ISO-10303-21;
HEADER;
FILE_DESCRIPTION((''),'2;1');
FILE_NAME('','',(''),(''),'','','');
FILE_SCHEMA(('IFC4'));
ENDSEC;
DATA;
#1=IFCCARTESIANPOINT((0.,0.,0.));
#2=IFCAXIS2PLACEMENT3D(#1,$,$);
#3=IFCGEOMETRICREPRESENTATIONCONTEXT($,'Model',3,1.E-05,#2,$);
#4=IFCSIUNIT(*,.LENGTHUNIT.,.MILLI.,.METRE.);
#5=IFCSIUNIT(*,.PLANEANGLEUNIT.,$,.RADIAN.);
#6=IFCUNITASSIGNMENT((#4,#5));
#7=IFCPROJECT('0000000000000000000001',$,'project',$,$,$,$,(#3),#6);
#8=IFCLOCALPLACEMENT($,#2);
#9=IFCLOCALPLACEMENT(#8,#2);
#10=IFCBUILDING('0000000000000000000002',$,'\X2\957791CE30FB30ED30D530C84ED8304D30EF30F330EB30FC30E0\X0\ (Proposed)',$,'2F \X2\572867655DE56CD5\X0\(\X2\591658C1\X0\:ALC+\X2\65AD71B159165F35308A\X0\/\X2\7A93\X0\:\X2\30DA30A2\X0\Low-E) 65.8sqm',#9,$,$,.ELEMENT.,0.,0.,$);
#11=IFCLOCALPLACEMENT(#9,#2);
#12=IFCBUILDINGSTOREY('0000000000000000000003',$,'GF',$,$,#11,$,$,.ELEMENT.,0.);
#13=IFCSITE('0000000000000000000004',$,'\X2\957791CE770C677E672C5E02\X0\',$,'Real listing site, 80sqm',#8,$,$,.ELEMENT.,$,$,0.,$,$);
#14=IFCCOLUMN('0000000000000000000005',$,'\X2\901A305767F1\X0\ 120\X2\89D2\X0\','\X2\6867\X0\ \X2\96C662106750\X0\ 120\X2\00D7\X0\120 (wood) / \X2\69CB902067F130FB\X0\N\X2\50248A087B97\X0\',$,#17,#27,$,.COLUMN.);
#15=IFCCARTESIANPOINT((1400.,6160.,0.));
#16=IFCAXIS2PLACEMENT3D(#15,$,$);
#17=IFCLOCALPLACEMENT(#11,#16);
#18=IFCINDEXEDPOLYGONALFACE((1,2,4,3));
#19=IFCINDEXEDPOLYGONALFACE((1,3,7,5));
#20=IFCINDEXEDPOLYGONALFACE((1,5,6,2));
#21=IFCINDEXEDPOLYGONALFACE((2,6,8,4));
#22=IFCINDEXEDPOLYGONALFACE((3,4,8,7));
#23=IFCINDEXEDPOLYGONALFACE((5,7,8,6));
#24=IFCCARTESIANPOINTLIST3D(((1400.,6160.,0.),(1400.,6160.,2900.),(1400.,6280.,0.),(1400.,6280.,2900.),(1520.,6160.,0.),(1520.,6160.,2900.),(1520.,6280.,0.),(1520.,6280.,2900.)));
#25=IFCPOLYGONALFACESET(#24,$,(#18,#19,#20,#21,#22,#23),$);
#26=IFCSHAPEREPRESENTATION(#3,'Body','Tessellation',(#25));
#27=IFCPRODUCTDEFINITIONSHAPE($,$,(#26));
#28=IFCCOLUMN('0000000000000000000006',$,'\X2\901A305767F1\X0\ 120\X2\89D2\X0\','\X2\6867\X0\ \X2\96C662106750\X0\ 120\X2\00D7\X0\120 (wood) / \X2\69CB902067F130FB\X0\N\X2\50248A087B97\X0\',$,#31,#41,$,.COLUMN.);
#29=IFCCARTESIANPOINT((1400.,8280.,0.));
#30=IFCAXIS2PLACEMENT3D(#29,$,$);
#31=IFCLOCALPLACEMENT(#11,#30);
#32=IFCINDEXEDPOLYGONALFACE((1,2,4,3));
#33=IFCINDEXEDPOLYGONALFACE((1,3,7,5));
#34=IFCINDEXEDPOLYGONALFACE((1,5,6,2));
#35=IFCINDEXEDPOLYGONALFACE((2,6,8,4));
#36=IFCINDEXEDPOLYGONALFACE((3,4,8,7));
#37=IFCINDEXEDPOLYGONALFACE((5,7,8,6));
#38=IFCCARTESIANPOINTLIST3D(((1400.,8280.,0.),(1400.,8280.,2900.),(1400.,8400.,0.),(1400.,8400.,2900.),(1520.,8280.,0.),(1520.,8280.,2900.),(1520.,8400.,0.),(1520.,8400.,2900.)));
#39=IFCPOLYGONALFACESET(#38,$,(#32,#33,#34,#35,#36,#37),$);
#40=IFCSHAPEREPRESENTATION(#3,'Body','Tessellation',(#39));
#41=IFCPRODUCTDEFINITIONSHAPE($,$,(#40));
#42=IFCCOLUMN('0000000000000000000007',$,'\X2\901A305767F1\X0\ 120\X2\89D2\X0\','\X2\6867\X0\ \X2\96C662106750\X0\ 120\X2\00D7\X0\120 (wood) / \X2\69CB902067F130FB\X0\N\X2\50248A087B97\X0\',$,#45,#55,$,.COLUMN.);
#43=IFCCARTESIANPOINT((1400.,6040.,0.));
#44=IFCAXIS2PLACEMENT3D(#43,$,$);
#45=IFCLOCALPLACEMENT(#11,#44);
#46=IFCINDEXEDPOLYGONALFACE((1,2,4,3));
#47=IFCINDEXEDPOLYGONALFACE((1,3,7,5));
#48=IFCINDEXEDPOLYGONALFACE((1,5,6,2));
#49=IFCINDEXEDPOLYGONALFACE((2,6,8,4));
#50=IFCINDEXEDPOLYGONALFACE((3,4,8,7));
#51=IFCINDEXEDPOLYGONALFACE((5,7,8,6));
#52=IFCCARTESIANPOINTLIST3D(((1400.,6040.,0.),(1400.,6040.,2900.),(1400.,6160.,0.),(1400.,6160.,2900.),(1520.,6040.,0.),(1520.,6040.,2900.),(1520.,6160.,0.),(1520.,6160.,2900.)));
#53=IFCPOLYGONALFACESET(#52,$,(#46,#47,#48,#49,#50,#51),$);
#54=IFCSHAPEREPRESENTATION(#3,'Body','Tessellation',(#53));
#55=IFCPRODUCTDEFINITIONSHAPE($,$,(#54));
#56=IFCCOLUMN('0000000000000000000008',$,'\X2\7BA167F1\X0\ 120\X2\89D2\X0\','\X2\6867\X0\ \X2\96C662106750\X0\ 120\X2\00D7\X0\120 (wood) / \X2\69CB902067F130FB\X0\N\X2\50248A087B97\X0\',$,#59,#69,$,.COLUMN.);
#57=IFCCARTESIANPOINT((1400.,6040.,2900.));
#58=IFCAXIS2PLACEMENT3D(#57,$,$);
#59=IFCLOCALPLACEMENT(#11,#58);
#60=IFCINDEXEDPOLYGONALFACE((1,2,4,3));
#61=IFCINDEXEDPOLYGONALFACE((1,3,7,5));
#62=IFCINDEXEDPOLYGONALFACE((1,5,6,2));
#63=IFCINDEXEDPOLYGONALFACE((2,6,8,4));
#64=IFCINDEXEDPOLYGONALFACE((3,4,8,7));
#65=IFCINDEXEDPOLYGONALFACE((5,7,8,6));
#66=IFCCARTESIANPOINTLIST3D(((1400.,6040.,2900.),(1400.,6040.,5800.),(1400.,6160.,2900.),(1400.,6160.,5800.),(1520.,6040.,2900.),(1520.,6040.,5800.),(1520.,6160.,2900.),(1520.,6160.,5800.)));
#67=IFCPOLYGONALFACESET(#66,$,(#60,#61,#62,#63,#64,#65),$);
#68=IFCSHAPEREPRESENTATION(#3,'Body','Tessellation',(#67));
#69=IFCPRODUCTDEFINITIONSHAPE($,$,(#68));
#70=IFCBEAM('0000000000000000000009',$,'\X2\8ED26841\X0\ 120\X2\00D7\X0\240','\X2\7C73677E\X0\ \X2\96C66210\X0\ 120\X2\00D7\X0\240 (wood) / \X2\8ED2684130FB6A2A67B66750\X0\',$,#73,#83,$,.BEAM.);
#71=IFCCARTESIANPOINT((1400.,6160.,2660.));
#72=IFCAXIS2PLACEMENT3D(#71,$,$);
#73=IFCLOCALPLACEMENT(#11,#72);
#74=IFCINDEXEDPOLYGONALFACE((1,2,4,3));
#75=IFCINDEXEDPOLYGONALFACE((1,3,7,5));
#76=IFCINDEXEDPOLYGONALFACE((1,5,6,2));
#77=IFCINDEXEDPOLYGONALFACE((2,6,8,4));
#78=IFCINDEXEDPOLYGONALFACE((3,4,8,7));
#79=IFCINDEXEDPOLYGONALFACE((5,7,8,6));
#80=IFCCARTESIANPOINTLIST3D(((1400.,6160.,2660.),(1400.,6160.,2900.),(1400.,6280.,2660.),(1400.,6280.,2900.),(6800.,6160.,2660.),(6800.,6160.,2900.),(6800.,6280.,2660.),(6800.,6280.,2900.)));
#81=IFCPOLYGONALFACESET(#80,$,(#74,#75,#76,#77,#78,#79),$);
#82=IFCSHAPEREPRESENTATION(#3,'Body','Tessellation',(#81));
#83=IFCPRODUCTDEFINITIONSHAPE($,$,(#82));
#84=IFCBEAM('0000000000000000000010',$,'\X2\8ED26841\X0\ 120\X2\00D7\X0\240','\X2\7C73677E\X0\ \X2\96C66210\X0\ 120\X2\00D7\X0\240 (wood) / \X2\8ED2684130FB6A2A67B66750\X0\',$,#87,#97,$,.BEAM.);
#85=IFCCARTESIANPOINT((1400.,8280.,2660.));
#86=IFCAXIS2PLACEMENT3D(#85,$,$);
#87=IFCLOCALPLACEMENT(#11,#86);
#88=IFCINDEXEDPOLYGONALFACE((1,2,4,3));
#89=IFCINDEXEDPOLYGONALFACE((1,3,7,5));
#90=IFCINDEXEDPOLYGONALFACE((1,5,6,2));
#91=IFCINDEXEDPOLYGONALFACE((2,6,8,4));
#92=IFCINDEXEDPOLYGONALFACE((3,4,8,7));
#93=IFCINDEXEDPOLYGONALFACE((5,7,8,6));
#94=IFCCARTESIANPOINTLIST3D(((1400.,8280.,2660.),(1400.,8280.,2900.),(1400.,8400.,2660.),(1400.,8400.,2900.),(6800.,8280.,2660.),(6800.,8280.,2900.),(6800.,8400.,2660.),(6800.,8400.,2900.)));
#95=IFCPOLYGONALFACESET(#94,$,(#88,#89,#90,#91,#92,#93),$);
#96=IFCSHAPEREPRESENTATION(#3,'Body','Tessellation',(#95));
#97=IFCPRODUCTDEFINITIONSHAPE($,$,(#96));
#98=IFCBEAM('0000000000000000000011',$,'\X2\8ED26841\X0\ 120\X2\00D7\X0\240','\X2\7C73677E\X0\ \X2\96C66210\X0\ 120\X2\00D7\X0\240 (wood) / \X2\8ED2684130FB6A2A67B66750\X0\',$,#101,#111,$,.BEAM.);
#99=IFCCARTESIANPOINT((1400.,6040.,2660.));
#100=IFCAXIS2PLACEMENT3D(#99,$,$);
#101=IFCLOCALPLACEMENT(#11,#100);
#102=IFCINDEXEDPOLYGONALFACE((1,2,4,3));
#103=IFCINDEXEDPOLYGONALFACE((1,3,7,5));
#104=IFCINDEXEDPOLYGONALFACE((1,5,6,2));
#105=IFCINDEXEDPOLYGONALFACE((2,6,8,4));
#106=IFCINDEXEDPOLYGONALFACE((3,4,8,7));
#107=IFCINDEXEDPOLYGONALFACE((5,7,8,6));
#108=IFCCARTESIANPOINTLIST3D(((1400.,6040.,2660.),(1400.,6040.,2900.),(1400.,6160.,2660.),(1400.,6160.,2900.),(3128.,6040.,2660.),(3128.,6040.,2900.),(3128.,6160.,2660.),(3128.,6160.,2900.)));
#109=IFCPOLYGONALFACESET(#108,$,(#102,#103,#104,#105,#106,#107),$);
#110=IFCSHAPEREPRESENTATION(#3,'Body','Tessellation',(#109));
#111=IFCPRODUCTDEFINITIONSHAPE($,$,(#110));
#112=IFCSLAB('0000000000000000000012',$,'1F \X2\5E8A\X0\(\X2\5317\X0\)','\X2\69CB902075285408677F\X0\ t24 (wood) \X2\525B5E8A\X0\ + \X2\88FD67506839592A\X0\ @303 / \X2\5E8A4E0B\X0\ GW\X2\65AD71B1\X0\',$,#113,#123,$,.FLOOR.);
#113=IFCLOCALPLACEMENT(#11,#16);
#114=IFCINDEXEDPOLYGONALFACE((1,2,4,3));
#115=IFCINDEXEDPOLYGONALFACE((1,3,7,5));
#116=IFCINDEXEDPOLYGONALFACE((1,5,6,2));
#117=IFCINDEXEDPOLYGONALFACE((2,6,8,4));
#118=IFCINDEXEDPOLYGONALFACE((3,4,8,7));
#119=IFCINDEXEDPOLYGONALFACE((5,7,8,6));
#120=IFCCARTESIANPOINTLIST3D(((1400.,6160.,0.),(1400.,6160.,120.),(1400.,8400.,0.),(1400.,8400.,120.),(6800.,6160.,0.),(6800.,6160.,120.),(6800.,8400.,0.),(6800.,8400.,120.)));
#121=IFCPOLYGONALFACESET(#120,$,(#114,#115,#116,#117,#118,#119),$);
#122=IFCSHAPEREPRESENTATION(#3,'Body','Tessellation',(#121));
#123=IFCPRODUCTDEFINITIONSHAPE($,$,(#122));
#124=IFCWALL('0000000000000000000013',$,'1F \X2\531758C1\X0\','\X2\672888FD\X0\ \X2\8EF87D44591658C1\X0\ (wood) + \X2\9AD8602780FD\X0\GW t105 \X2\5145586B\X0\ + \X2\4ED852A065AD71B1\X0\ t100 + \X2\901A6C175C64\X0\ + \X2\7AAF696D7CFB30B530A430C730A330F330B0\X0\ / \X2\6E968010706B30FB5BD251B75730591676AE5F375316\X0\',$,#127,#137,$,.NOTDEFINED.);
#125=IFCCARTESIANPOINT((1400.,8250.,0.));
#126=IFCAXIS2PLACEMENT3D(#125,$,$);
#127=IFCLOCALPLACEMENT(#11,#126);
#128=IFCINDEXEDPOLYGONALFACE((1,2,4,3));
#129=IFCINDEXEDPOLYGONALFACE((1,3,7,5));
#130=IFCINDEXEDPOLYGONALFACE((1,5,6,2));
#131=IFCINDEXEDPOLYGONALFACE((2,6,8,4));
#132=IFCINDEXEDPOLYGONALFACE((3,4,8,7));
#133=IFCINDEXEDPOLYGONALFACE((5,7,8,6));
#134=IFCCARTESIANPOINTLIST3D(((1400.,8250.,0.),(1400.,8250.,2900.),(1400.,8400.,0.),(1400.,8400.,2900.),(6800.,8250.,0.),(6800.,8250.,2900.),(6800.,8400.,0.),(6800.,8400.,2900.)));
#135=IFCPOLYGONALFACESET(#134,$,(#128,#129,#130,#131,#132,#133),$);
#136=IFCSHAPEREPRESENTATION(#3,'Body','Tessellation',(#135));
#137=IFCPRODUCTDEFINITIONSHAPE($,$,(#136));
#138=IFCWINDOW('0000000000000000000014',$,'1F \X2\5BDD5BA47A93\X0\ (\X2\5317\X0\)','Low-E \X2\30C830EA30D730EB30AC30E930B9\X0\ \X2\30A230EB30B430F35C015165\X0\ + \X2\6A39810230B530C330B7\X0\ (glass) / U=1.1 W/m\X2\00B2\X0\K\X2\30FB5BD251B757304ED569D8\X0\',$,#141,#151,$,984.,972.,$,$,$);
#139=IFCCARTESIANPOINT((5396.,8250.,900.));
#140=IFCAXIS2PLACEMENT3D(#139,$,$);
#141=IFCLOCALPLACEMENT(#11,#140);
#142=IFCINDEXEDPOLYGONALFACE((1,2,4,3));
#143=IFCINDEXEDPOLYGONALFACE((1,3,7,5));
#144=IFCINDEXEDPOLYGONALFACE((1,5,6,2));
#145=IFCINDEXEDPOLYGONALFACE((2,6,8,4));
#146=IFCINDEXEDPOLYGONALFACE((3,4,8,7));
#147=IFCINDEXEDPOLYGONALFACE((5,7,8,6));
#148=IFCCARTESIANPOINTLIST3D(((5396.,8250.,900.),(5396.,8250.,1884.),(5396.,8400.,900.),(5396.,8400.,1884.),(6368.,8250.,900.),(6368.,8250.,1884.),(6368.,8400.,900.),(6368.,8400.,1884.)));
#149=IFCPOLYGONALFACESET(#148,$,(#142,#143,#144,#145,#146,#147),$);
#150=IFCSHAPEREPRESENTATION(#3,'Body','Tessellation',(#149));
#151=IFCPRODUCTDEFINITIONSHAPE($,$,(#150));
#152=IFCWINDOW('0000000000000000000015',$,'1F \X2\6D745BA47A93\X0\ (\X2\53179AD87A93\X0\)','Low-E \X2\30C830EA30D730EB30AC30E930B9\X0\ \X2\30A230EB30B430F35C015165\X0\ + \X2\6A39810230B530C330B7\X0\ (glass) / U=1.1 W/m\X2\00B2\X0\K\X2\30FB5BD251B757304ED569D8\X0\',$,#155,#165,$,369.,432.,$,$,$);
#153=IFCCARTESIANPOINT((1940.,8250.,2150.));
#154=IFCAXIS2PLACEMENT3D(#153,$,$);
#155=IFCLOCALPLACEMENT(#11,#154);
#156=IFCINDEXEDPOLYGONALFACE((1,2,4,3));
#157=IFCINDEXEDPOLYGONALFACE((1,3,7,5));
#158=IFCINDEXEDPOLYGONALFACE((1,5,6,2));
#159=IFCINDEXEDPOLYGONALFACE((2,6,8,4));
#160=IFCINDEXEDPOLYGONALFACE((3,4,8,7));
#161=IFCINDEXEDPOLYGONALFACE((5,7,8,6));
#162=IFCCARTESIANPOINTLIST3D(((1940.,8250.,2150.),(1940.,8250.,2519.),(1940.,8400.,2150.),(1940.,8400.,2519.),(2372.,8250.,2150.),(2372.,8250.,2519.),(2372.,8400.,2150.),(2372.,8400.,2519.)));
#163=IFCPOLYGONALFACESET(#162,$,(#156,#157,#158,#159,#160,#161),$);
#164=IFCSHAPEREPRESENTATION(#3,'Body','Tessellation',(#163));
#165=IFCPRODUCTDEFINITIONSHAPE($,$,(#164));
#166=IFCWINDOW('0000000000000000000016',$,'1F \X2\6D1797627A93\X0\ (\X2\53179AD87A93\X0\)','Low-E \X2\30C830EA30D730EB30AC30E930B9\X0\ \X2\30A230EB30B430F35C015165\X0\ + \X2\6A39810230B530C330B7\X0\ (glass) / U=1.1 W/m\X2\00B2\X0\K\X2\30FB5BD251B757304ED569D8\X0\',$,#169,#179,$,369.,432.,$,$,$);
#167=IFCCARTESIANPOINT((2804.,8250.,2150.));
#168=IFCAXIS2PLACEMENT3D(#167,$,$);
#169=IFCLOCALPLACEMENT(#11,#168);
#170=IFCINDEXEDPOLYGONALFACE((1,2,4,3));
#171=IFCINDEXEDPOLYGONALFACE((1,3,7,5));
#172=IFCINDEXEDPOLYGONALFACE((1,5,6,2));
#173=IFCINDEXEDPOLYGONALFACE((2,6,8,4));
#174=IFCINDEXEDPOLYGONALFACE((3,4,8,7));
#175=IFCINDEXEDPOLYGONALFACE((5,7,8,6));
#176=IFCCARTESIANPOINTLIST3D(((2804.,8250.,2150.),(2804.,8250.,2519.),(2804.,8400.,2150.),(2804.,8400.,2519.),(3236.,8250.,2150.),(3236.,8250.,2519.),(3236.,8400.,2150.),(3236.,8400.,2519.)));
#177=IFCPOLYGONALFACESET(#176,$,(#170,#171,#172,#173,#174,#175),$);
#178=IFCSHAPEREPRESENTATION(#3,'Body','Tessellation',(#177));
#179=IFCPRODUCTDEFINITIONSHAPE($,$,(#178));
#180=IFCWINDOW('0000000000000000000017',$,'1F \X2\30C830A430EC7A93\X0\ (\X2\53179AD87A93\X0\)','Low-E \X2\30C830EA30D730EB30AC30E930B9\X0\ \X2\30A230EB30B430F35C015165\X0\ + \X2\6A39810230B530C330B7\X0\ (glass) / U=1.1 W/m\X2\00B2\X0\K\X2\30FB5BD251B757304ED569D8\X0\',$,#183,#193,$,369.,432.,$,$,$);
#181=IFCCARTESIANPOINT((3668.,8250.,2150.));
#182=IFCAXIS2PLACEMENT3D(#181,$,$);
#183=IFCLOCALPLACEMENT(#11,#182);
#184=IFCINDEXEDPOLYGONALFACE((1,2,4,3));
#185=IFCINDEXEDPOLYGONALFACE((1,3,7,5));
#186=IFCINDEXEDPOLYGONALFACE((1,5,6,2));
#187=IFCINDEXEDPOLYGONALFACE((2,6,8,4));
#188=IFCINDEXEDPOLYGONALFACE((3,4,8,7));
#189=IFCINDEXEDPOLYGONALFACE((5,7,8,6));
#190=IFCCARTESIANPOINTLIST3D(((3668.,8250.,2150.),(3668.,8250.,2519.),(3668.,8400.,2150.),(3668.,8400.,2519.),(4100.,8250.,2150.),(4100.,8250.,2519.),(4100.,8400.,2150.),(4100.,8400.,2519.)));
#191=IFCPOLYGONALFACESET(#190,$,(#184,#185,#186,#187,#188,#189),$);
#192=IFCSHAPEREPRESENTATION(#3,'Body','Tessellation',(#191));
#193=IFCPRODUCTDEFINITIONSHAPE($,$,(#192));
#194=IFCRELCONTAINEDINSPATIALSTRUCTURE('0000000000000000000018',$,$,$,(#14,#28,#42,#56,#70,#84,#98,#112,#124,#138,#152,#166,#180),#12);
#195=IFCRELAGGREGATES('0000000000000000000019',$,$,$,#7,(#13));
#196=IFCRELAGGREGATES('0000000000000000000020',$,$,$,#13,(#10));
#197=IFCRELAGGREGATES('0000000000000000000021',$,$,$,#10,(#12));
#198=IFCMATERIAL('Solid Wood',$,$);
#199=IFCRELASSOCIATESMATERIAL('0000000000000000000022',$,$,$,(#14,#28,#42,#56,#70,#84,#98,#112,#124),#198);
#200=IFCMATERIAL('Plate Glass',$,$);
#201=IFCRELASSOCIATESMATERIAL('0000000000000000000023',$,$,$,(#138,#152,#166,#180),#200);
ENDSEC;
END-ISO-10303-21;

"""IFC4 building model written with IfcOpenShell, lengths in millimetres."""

from ifc_helpers import new_model, si_unit, frame, frame_2d, origin, place, context, project, spatial, rectangle, extrude, material, element, fill, save


model = new_model("IFC4")

# Units and contexts
model_context = context("Model", 3, precision=1e-05, world=origin())
ifc_project = project(units=[si_unit("LENGTHUNIT", "METRE", prefix="MILLI"), si_unit("PLANEANGLEUNIT", "RADIAN")], contexts=[model_context])

# Site, building, storey
site_placement = place(None, origin())
site = spatial("IfcSite", under=ifc_project, at=site_placement, Name="長野県松本市", ObjectType="Real listing site, 80sqm", CompositionType="ELEMENT", RefElevation=0.0)
building_placement = place(site_placement, origin())
building = spatial("IfcBuilding", under=site, at=building_placement, Name="長野・ロフト付きワンルーム (Proposed)", ObjectType="2F 在来工法(外壁:ALC+断熱外張り/窓:ペアLow-E) 65.8sqm", CompositionType="ELEMENT", ElevationOfRefHeight=0.0, ElevationOfTerrain=0.0)
storey_placement = place(building_placement, origin())
storey = spatial("IfcBuildingStorey", under=building, at=storey_placement, Name="GF", CompositionType="ELEMENT", Elevation=0.0)

# Columns
ifc_material_1 = material(Name="Solid Wood")
column_1_placement = place(storey_placement, frame((1400.0, 6160.0, 0.0)))
element("IfcColumn", 1, at=column_1_placement, inside=storey, material=ifc_material_1, Name="通し柱 120角", Description="桧 集成材 120×120 (wood) / 構造柱・N値計算", PredefinedType="COLUMN", context=model_context, shape_type="SweptSolid", body=[
    extrude(rectangle(XDim=120.0, YDim=120.0, at=frame_2d((60.0, 60.0))), frame((1400.0, 6160.0, 0.0)), (0.0, 0.0, 1.0), 2900.0),
])
column_2_placement = place(storey_placement, frame((1400.0, 8280.0, 0.0)))
element("IfcColumn", 2, at=column_2_placement, inside=storey, material=ifc_material_1, Name="通し柱 120角", Description="桧 集成材 120×120 (wood) / 構造柱・N値計算", PredefinedType="COLUMN", context=model_context, shape_type="SweptSolid", body=[
    extrude(rectangle(XDim=120.0, YDim=120.0, at=frame_2d((60.0, 60.0))), frame((1400.0, 8280.0, 0.0)), (0.0, 0.0, 1.0), 2900.0),
])
column_3_placement = place(storey_placement, frame((1400.0, 6040.0, 0.0)))
element("IfcColumn", 3, at=column_3_placement, inside=storey, material=ifc_material_1, Name="通し柱 120角", Description="桧 集成材 120×120 (wood) / 構造柱・N値計算", PredefinedType="COLUMN", context=model_context, shape_type="SweptSolid", body=[
    extrude(rectangle(XDim=120.0, YDim=120.0, at=frame_2d((60.0, 60.0))), frame((1400.0, 6040.0, 0.0)), (0.0, 0.0, 1.0), 2900.0),
])
column_4_placement = place(storey_placement, frame((1400.0, 6040.0, 2900.0)))
element("IfcColumn", 4, at=column_4_placement, inside=storey, material=ifc_material_1, Name="管柱 120角", Description="桧 集成材 120×120 (wood) / 構造柱・N値計算", PredefinedType="COLUMN", context=model_context, shape_type="SweptSolid", body=[
    extrude(rectangle(XDim=120.0, YDim=120.0, at=frame_2d((60.0, 60.0))), frame((1400.0, 6040.0, 2900.0)), (0.0, 0.0, 1.0), 2900.0),
])

# Beams
beam_1_placement = place(storey_placement, frame((1400.0, 6160.0, 2660.0)))
element("IfcBeam", 5, at=beam_1_placement, inside=storey, material=ifc_material_1, Name="軒桁 120×240", Description="米松 集成 120×240 (wood) / 軒桁・横架材", PredefinedType="BEAM", context=model_context, shape_type="SweptSolid", body=[
    extrude(rectangle(XDim=5400.0, YDim=120.0, at=frame_2d((2700.0, 60.0))), frame((1400.0, 6160.0, 2660.0)), (0.0, 0.0, 1.0), 240.0),
])
beam_2_placement = place(storey_placement, frame((1400.0, 8280.0, 2660.0)))
element("IfcBeam", 6, at=beam_2_placement, inside=storey, material=ifc_material_1, Name="軒桁 120×240", Description="米松 集成 120×240 (wood) / 軒桁・横架材", PredefinedType="BEAM", context=model_context, shape_type="SweptSolid", body=[
    extrude(rectangle(XDim=5400.0, YDim=120.0, at=frame_2d((2700.0, 60.0))), frame((1400.0, 8280.0, 2660.0)), (0.0, 0.0, 1.0), 240.0),
])
beam_3_placement = place(storey_placement, frame((1400.0, 6040.0, 2660.0)))
element("IfcBeam", 7, at=beam_3_placement, inside=storey, material=ifc_material_1, Name="軒桁 120×240", Description="米松 集成 120×240 (wood) / 軒桁・横架材", PredefinedType="BEAM", context=model_context, shape_type="SweptSolid", body=[
    extrude(rectangle(XDim=1728.0, YDim=120.0, at=frame_2d((864.0, 60.0))), frame((1400.0, 6040.0, 2660.0)), (0.0, 0.0, 1.0), 240.0),
])

# Slab
slab_placement = place(storey_placement, frame((1400.0, 6160.0, 0.0)))
element("IfcSlab", 8, at=slab_placement, inside=storey, material=ifc_material_1, Name="1F 床(北)", Description="構造用合板 t24 (wood) 剛床 + 製材根太 @303 / 床下 GW断熱", PredefinedType="FLOOR", context=model_context, shape_type="SweptSolid", body=[
    extrude(rectangle(XDim=5400.0, YDim=2240.0, at=frame_2d((2700.0, 1120.0))), frame((1400.0, 6160.0, 0.0)), (0.0, 0.0, 1.0), 120.0),
])

# Wall, openings, windows
wall_1_placement = place(storey_placement, frame((1400.0, 8250.0, 0.0)))
wall_1 = element("IfcWall", 9, at=wall_1_placement, inside=storey, material=ifc_material_1, Name="1F 北壁", Description="木製 軸組外壁 (wood) + 高性能GW t105 充填 + 付加断熱 t100 + 通気層 + 窯業系サイディング / 準耐火・寒冷地外皮強化", PredefinedType="NOTDEFINED", context=model_context, shape_type="SweptSolid", body=[
    extrude(rectangle(XDim=5400.0, YDim=150.0, at=frame_2d((2700.0, 75.0))), frame((1400.0, 8250.0, 0.0)), (0.0, 0.0, 1.0), 2900.0),
])
opening_1_placement = place(storey_placement, frame((5396.0, 8250.0, 900.0)))
opening_1 = element("IfcOpeningElement", 10, at=opening_1_placement, cuts=wall_1, PredefinedType="NOTDEFINED", context=model_context, shape_type="SweptSolid", body=[
    extrude(rectangle(XDim=972.0, YDim=150.0, at=frame_2d((486.0, 75.0))), frame((5396.0, 8250.0, 900.0)), (0.0, 0.0, 1.0), 984.0),
])
opening_2_placement = place(storey_placement, frame((1940.0, 8250.0, 2150.0)))
opening_2 = element("IfcOpeningElement", 11, at=opening_2_placement, cuts=wall_1, PredefinedType="NOTDEFINED", context=model_context, shape_type="SweptSolid", body=[
    extrude(rectangle(XDim=432.0, YDim=150.0, at=frame_2d((216.0, 75.0))), frame((1940.0, 8250.0, 2150.0)), (0.0, 0.0, 1.0), 369.0),
])
opening_3_placement = place(storey_placement, frame((2804.0, 8250.0, 2150.0)))
opening_3 = element("IfcOpeningElement", 12, at=opening_3_placement, cuts=wall_1, PredefinedType="NOTDEFINED", context=model_context, shape_type="SweptSolid", body=[
    extrude(rectangle(XDim=432.0, YDim=150.0, at=frame_2d((216.0, 75.0))), frame((2804.0, 8250.0, 2150.0)), (0.0, 0.0, 1.0), 369.0),
])
opening_4_placement = place(storey_placement, frame((3668.0, 8250.0, 2150.0)))
opening_4 = element("IfcOpeningElement", 13, at=opening_4_placement, cuts=wall_1, PredefinedType="NOTDEFINED", context=model_context, shape_type="SweptSolid", body=[
    extrude(rectangle(XDim=432.0, YDim=150.0, at=frame_2d((216.0, 75.0))), frame((3668.0, 8250.0, 2150.0)), (0.0, 0.0, 1.0), 369.0),
])
ifc_material_2 = material(Name="Plate Glass")
window_1_placement = place(storey_placement, frame((5396.0, 8250.0, 900.0)))
window_1 = element("IfcWindow", 14, at=window_1_placement, inside=storey, material=ifc_material_2, Name="1F 寝室窓 (北)", Description="Low-E トリプルガラス アルゴン封入 + 樹脂サッシ (glass) / U=1.1 W/m²K・寒冷地仕様", OverallHeight=984.0, OverallWidth=972.0, context=model_context, shape_type="SweptSolid", body=[
    extrude(rectangle(XDim=972.0, YDim=150.0, at=frame_2d((486.0, 75.0))), frame((5396.0, 8250.0, 900.0)), (0.0, 0.0, 1.0), 984.0),
])
fill(opening_1, window_1)
window_2_placement = place(storey_placement, frame((1940.0, 8250.0, 2150.0)))
window_2 = element("IfcWindow", 15, at=window_2_placement, inside=storey, material=ifc_material_2, Name="1F 浴室窓 (北高窓)", Description="Low-E トリプルガラス アルゴン封入 + 樹脂サッシ (glass) / U=1.1 W/m²K・寒冷地仕様", OverallHeight=369.0, OverallWidth=432.0, context=model_context, shape_type="SweptSolid", body=[
    extrude(rectangle(XDim=432.0, YDim=150.0, at=frame_2d((216.0, 75.0))), frame((1940.0, 8250.0, 2150.0)), (0.0, 0.0, 1.0), 369.0),
])
fill(opening_2, window_2)
window_3_placement = place(storey_placement, frame((2804.0, 8250.0, 2150.0)))
window_3 = element("IfcWindow", 16, at=window_3_placement, inside=storey, material=ifc_material_2, Name="1F 洗面窓 (北高窓)", Description="Low-E トリプルガラス アルゴン封入 + 樹脂サッシ (glass) / U=1.1 W/m²K・寒冷地仕様", OverallHeight=369.0, OverallWidth=432.0, context=model_context, shape_type="SweptSolid", body=[
    extrude(rectangle(XDim=432.0, YDim=150.0, at=frame_2d((216.0, 75.0))), frame((2804.0, 8250.0, 2150.0)), (0.0, 0.0, 1.0), 369.0),
])
fill(opening_3, window_3)
window_4_placement = place(storey_placement, frame((3668.0, 8250.0, 2150.0)))
window_4 = element("IfcWindow", 17, at=window_4_placement, inside=storey, material=ifc_material_2, Name="1F トイレ窓 (北高窓)", Description="Low-E トリプルガラス アルゴン封入 + 樹脂サッシ (glass) / U=1.1 W/m²K・寒冷地仕様", OverallHeight=369.0, OverallWidth=432.0, context=model_context, shape_type="SweptSolid", body=[
    extrude(rectangle(XDim=432.0, YDim=150.0, at=frame_2d((216.0, 75.0))), frame((3668.0, 8250.0, 2150.0)), (0.0, 0.0, 1.0), 369.0),
])
fill(opening_4, window_4)

save(model, "model.ifc")
